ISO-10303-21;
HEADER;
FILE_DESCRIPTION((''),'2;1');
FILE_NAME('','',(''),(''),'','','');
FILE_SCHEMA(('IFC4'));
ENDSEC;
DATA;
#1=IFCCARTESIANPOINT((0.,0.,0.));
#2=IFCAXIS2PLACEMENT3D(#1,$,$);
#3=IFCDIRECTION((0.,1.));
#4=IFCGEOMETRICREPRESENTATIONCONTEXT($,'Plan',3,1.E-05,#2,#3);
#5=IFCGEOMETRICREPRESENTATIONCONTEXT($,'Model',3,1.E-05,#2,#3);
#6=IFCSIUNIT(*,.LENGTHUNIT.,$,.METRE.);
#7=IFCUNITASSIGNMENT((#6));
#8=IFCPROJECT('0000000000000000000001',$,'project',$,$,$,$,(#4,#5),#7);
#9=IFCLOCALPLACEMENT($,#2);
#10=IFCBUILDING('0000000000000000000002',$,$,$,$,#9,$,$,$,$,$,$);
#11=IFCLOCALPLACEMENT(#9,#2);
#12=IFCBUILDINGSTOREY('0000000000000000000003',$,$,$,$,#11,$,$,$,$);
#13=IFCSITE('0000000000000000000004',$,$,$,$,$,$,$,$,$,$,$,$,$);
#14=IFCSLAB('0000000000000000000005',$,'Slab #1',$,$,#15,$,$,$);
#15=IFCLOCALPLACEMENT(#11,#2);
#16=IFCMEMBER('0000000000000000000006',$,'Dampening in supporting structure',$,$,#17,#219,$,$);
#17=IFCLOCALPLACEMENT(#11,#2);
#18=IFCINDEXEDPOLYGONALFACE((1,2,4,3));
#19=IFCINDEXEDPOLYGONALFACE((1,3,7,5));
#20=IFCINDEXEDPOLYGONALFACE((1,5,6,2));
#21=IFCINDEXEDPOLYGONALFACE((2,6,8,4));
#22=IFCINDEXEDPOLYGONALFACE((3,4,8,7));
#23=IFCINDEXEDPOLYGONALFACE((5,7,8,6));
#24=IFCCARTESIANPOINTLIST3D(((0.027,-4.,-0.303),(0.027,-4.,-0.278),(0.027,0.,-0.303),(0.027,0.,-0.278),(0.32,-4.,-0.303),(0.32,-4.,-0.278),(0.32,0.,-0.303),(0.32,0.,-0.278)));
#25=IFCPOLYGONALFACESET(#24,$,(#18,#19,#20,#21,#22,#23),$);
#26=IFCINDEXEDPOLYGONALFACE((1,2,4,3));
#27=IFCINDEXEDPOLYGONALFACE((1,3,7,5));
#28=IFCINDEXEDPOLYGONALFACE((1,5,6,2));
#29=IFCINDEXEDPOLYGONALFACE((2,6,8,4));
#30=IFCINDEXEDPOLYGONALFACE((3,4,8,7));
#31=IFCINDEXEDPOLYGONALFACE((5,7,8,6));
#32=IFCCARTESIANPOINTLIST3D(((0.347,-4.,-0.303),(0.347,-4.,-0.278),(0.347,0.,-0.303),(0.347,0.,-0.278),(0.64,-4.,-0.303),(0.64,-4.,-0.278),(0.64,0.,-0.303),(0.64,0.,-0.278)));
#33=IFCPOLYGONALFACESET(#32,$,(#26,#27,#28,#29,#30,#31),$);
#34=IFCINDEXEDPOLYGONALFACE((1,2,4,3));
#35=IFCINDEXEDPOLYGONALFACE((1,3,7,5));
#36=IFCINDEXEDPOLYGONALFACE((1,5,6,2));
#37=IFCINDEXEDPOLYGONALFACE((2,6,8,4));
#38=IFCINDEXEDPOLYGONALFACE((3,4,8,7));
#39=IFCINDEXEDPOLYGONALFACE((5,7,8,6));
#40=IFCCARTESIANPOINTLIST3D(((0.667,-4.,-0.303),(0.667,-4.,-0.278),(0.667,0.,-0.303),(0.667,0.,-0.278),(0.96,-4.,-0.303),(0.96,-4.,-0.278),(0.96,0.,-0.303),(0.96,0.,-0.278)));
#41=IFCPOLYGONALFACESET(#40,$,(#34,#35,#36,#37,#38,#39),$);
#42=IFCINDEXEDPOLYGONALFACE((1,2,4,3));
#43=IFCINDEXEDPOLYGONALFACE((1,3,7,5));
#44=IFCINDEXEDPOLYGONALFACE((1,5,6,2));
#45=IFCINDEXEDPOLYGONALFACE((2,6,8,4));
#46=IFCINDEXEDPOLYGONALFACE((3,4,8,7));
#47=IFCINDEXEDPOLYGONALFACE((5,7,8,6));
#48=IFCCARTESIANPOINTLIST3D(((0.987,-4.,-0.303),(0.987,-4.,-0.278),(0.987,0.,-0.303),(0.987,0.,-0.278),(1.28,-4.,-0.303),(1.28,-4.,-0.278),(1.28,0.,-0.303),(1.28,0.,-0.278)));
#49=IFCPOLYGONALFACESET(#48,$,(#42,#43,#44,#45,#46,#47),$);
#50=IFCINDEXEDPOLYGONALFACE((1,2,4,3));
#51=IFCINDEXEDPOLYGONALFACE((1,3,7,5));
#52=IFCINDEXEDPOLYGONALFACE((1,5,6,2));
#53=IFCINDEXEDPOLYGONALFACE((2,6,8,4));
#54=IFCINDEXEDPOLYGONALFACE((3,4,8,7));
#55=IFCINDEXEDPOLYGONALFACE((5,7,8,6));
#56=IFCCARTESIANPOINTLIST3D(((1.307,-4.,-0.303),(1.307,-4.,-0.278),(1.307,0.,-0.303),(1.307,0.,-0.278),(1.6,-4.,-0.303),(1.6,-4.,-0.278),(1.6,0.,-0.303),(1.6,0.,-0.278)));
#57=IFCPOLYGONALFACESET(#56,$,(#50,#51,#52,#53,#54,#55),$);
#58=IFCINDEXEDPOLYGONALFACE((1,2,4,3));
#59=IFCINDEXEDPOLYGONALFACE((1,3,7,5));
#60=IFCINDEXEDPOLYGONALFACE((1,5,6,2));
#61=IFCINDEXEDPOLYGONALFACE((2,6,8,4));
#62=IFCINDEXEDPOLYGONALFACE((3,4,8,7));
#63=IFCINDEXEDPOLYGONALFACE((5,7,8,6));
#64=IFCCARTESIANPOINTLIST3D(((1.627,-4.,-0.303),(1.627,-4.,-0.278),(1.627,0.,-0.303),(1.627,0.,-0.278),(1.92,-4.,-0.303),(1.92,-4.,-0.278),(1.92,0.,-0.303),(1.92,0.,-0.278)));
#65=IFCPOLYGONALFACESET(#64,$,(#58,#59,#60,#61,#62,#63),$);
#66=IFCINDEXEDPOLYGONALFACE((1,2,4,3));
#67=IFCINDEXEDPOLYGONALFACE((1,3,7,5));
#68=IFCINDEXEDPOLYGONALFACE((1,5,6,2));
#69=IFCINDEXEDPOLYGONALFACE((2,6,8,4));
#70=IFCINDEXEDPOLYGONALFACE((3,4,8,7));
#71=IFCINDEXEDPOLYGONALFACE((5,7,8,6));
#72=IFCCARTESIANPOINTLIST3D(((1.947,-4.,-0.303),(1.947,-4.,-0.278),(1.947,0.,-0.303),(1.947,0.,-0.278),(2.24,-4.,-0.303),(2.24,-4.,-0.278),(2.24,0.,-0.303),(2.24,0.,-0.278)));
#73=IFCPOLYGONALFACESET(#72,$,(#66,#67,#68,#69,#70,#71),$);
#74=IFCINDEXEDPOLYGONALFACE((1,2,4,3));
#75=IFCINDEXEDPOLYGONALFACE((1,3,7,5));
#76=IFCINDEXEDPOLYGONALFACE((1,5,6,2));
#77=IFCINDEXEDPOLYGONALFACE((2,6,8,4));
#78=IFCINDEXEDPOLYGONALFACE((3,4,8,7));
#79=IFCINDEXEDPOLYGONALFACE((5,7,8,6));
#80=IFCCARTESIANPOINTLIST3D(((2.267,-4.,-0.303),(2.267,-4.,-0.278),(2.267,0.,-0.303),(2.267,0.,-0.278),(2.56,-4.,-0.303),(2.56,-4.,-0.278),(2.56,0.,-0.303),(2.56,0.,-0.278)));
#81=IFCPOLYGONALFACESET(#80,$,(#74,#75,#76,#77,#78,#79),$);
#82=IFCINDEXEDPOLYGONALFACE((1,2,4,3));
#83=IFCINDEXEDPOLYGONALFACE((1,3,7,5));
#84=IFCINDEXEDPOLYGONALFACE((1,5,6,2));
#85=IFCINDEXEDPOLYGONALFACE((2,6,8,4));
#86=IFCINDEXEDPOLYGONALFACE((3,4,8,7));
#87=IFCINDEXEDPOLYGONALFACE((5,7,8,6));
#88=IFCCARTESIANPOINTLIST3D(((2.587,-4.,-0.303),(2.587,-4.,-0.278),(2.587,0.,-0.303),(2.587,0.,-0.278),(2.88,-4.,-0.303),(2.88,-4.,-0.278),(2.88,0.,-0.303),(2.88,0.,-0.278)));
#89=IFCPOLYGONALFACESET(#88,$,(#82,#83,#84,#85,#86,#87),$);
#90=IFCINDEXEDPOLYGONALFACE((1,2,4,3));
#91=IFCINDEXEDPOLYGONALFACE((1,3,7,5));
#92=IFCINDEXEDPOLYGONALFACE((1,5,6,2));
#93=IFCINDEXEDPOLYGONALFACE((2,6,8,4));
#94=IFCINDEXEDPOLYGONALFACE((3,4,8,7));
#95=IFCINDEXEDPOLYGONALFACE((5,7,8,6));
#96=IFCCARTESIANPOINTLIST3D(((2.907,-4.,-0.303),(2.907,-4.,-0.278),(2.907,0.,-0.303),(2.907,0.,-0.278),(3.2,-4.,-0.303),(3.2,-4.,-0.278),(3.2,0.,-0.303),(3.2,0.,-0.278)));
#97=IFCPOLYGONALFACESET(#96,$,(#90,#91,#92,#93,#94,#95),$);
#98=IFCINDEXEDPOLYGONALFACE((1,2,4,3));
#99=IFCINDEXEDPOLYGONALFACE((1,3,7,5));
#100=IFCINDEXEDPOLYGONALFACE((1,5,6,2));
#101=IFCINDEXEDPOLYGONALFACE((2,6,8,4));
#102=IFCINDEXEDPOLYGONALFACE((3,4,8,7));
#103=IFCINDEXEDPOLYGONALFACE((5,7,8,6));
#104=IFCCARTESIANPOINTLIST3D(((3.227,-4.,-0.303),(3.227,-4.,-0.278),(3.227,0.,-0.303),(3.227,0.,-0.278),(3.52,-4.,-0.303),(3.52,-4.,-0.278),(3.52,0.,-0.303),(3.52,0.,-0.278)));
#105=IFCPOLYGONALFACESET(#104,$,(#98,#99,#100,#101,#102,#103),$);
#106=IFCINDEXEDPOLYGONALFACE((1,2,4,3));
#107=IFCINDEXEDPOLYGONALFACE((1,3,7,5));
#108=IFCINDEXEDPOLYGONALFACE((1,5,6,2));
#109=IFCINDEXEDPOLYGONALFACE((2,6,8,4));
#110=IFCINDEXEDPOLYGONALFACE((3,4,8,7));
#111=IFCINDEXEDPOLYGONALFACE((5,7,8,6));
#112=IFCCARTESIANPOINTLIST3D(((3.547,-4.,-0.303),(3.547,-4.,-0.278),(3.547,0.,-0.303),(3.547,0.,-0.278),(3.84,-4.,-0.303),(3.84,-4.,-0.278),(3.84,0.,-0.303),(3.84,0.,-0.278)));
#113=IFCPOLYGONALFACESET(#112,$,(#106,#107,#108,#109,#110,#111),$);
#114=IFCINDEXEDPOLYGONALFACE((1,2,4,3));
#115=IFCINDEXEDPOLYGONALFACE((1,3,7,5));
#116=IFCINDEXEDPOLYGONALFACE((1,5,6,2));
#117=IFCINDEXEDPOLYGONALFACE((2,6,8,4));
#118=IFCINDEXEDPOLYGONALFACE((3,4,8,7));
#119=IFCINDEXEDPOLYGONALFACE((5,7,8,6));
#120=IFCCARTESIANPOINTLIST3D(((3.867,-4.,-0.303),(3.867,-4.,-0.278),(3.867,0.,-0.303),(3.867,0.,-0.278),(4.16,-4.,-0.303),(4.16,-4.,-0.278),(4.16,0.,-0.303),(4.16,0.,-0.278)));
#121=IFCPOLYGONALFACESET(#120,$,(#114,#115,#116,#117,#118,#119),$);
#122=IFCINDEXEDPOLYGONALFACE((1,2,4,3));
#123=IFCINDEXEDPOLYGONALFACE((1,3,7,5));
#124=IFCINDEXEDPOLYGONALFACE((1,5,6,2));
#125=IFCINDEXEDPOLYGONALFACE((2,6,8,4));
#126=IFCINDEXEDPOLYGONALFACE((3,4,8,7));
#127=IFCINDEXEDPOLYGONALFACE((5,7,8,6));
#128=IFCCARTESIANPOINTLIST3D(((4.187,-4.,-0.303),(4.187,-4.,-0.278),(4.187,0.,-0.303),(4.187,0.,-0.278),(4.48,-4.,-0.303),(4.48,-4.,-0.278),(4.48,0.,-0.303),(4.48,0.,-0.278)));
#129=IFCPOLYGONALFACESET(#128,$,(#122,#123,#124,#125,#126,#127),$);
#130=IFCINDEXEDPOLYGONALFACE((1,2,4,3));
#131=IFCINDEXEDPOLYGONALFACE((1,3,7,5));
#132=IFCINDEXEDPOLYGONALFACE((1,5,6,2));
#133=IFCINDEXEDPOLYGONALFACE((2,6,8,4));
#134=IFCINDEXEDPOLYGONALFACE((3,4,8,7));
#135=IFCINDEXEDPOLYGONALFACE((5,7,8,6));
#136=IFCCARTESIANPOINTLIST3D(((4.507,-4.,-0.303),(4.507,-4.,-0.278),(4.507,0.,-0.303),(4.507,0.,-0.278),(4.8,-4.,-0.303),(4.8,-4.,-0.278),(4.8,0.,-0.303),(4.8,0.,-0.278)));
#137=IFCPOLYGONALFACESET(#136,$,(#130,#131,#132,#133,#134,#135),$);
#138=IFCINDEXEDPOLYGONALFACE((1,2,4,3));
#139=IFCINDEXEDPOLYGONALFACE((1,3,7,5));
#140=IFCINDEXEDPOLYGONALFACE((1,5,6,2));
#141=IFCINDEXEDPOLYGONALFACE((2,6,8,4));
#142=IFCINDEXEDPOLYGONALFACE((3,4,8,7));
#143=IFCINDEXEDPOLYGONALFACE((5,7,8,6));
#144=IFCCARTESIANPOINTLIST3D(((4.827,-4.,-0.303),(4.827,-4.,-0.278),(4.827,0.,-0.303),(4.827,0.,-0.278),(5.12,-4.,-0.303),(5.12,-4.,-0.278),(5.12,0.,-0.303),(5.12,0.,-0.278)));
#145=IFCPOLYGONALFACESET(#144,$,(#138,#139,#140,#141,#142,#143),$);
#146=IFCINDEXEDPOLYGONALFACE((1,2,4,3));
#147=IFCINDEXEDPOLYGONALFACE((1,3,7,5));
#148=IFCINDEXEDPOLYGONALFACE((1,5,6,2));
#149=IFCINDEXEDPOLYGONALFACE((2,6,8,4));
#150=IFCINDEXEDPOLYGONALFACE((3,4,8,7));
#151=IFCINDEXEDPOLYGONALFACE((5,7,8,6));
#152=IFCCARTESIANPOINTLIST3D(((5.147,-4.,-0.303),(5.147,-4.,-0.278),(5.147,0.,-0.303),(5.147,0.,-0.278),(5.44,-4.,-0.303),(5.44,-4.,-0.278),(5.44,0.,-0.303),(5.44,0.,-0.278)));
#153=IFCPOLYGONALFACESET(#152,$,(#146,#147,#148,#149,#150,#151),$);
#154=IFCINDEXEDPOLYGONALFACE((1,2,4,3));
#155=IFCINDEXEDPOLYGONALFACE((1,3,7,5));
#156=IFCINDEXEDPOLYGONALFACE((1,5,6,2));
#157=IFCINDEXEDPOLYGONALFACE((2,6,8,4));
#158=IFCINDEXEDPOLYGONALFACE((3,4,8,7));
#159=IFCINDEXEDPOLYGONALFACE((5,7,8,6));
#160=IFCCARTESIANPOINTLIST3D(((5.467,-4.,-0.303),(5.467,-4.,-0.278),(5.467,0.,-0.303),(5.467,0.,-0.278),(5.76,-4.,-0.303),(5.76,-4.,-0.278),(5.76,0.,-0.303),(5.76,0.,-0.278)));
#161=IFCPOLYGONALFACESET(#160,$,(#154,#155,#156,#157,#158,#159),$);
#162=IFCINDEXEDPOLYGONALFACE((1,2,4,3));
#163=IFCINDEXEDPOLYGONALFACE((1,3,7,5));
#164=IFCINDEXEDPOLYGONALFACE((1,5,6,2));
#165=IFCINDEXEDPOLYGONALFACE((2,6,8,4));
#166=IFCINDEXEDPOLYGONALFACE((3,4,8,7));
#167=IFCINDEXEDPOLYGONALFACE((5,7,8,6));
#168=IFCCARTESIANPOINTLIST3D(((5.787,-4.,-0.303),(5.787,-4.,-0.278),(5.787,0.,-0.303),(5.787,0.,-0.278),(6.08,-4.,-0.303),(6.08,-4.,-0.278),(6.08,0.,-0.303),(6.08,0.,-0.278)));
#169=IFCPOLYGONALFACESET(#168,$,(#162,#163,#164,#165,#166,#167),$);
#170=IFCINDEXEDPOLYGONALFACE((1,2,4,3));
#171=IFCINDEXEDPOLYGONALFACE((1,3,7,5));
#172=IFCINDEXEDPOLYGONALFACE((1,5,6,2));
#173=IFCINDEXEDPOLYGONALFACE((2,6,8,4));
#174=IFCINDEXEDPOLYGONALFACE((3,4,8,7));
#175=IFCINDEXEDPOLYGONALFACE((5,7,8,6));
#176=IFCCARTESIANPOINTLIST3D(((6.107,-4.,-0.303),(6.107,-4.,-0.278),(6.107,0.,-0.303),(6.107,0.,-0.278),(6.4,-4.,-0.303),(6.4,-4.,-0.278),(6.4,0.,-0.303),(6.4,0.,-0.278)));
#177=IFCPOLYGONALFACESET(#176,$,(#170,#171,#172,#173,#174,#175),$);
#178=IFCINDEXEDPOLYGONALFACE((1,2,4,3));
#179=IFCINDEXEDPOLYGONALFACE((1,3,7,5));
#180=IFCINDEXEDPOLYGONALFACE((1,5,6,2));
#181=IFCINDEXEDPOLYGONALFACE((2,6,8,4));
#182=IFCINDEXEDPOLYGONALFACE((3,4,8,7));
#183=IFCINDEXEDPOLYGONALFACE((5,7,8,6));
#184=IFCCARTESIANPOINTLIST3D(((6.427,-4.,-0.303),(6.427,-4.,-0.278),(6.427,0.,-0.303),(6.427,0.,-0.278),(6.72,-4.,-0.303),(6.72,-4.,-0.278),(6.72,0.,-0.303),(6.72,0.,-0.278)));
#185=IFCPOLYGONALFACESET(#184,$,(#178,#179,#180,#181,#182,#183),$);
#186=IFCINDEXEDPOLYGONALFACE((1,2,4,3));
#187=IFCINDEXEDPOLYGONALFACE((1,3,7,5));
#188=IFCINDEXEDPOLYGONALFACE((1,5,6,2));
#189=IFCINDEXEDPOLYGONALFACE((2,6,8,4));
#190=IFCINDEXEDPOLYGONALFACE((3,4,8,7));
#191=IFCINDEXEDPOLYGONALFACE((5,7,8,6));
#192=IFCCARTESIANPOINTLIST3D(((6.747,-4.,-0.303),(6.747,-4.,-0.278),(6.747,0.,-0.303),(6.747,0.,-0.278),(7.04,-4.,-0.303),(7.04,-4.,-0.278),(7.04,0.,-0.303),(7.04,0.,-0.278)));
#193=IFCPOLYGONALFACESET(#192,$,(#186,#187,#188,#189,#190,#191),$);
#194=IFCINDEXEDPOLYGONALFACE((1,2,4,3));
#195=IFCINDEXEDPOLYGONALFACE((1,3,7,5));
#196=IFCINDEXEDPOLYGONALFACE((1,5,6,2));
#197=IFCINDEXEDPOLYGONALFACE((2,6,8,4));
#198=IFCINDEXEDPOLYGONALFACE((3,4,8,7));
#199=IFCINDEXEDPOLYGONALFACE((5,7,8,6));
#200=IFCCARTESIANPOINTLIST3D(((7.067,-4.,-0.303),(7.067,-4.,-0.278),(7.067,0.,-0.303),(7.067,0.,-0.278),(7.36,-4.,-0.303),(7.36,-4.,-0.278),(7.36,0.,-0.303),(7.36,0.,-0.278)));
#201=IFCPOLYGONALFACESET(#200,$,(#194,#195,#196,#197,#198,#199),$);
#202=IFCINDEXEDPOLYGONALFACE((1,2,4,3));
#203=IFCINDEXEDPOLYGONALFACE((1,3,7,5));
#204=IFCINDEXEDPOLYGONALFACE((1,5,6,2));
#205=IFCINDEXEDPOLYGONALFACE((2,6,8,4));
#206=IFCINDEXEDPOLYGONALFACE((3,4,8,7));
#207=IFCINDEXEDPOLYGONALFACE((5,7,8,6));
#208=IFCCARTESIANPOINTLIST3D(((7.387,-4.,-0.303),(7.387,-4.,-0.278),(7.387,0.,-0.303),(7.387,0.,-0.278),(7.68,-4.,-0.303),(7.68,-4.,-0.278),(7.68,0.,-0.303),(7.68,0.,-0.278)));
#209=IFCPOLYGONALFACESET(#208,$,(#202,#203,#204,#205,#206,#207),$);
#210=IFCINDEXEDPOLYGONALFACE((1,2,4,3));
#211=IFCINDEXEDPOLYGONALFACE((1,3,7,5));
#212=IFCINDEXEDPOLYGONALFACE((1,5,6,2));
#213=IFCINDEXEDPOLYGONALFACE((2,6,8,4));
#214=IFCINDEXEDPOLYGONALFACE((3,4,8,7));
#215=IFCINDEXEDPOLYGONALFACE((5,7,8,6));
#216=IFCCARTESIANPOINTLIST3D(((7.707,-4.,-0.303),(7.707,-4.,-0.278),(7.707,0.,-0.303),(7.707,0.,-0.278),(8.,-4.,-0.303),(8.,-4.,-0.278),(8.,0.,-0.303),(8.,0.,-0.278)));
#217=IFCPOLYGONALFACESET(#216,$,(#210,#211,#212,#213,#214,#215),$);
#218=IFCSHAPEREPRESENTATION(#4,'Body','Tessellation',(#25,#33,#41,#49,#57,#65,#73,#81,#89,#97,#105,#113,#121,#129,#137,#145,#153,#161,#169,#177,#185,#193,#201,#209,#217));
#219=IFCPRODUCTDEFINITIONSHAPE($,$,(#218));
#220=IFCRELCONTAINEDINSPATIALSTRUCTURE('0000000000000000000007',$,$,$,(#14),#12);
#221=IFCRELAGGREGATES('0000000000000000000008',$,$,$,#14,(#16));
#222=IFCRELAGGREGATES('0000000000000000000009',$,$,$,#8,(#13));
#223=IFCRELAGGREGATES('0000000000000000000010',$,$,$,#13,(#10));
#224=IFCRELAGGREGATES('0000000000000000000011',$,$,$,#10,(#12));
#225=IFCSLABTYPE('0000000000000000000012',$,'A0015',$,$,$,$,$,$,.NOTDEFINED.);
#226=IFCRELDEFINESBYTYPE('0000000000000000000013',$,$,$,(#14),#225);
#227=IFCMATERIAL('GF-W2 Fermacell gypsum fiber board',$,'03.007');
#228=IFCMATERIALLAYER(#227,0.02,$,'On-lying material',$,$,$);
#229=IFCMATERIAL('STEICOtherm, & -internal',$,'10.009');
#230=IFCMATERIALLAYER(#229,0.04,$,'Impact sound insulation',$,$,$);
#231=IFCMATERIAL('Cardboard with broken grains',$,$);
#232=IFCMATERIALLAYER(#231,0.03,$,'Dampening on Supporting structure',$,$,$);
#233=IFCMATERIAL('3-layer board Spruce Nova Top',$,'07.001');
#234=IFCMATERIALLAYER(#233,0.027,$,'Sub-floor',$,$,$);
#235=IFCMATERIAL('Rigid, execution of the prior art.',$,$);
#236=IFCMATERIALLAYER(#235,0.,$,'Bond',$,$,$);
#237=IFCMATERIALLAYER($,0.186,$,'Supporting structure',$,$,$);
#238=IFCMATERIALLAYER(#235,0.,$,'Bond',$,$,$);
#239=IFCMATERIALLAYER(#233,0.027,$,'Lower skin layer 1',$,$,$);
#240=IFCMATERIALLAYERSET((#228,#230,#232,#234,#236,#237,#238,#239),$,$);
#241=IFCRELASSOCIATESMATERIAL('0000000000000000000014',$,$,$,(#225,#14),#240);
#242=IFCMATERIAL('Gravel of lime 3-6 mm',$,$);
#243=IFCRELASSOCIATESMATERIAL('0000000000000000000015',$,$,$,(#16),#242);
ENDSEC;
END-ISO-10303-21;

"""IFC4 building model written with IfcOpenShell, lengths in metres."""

from ifc_helpers import new_model, si_unit, direction, frame, frame_2d, origin, place, context, project, spatial, rectangle, extrude, material, layer, layer_set, type_object, element, aggregate, save


model = new_model("IFC4")

# Units and contexts
plan_context = context("Plan", 3, precision=1e-05, world=origin(), true_north=direction((0.0, 1.0)))
model_context = context("Model", 3, precision=1e-05, world=origin(), true_north=direction((0.0, 1.0)))
ifc_project = project(units=[si_unit("LENGTHUNIT", "METRE")], contexts=[plan_context, model_context])

# Site, building, storey
site = spatial("IfcSite", under=ifc_project)
building_placement = place(None, origin())
building = spatial("IfcBuilding", under=site, at=building_placement)
storey_placement = place(building_placement, origin())
storey = spatial("IfcBuildingStorey", under=building, at=storey_placement)

# Slab, member
ifc_material_1 = material(Name="GF-W2 Fermacell gypsum fiber board", Category="03.007")
ifc_layer_1 = layer(ifc_material_1, 0.02, Name="On-lying material")
ifc_material_2 = material(Name="STEICOtherm, & -internal", Category="10.009")
ifc_layer_2 = layer(ifc_material_2, 0.04, Name="Impact sound insulation")
ifc_material_3 = material(Name="Cardboard with broken grains")
ifc_layer_3 = layer(ifc_material_3, 0.03, Name="Dampening on Supporting structure")
ifc_material_4 = material(Name="3-layer board Spruce Nova Top", Category="07.001")
ifc_layer_4 = layer(ifc_material_4, 0.027, Name="Sub-floor")
ifc_material_5 = material(Name="Rigid, execution of the prior art.")
ifc_layer_5 = layer(ifc_material_5, 0.0, Name="Bond")
ifc_layer_6 = layer(None, 0.186, Name="Supporting structure")
ifc_layer_7 = layer(ifc_material_5, 0.0, Name="Bond")
ifc_layer_8 = layer(ifc_material_4, 0.027, Name="Lower skin layer 1")
ifc_layer_set = layer_set([ifc_layer_1, ifc_layer_2, ifc_layer_3, ifc_layer_4, ifc_layer_5, ifc_layer_6, ifc_layer_7, ifc_layer_8])
slab_type = type_object("IfcSlabType", Name="A0015", PredefinedType="NOTDEFINED", material=ifc_layer_set)
slab_placement = place(None, frame((0.0, 0.0, 0.0), z_axis=(0.0, 0.0, -1.0), x_axis=(1.0, 0.0, 0.0)))
slab = element("IfcSlab", 1, at=slab_placement, inside=storey, type_object=slab_type, material=ifc_layer_set, Name="Slab #1")
ifc_material_6 = material(Name="Gravel of lime 3-6 mm")
member_1_placement = place(slab_placement, origin())
member_1 = element("IfcMember", 2, at=member_1_placement, material=ifc_material_6, Name="Dampening in supporting structure", context=plan_context, shape_type="SweptSolid", body=[
    extrude(rectangle(XDim=0.293, YDim=0.025, at=frame_2d((0.1465, 0.0125), x_axis=(1.0, 0.0))), frame((0.027, 4.0, 0.278), z_axis=(0.0, -1.0, 0.0), x_axis=(1.0, 0.0, 0.0)), (0.0, 0.0, 1.0), 4.0),
    extrude(rectangle(XDim=0.293, YDim=0.025, at=frame_2d((0.1465, 0.0125), x_axis=(1.0, 0.0))), frame((0.347, 4.0, 0.278), z_axis=(0.0, -1.0, 0.0), x_axis=(1.0, 0.0, 0.0)), (0.0, 0.0, 1.0), 4.0),
    extrude(rectangle(XDim=0.293, YDim=0.025, at=frame_2d((0.1465, 0.0125), x_axis=(1.0, 0.0))), frame((0.667, 4.0, 0.278), z_axis=(0.0, -1.0, 0.0), x_axis=(1.0, 0.0, 0.0)), (0.0, 0.0, 1.0), 4.0),
    extrude(rectangle(XDim=0.293, YDim=0.025, at=frame_2d((0.1465, 0.0125), x_axis=(1.0, 0.0))), frame((0.987, 4.0, 0.278), z_axis=(0.0, -1.0, 0.0), x_axis=(1.0, 0.0, 0.0)), (0.0, 0.0, 1.0), 4.0),
    extrude(rectangle(XDim=0.293, YDim=0.025, at=frame_2d((0.1465, 0.0125), x_axis=(1.0, 0.0))), frame((1.307, 4.0, 0.278), z_axis=(0.0, -1.0, 0.0), x_axis=(1.0, 0.0, 0.0)), (0.0, 0.0, 1.0), 4.0),
    extrude(rectangle(XDim=0.293, YDim=0.025, at=frame_2d((0.1465, 0.0125), x_axis=(1.0, 0.0))), frame((1.627, 4.0, 0.278), z_axis=(0.0, -1.0, 0.0), x_axis=(1.0, 0.0, 0.0)), (0.0, 0.0, 1.0), 4.0),
    extrude(rectangle(XDim=0.293, YDim=0.025, at=frame_2d((0.1465, 0.0125), x_axis=(1.0, 0.0))), frame((1.947, 4.0, 0.278), z_axis=(0.0, -1.0, 0.0), x_axis=(1.0, 0.0, 0.0)), (0.0, 0.0, 1.0), 4.0),
    extrude(rectangle(XDim=0.293, YDim=0.025, at=frame_2d((0.1465, 0.0125), x_axis=(1.0, 0.0))), frame((2.267, 4.0, 0.278), z_axis=(0.0, -1.0, 0.0), x_axis=(1.0, 0.0, 0.0)), (0.0, 0.0, 1.0), 4.0),
    extrude(rectangle(XDim=0.293, YDim=0.025, at=frame_2d((0.1465, 0.0125), x_axis=(1.0, 0.0))), frame((2.587, 4.0, 0.278), z_axis=(0.0, -1.0, 0.0), x_axis=(1.0, 0.0, 0.0)), (0.0, 0.0, 1.0), 4.0),
    extrude(rectangle(XDim=0.293, YDim=0.025, at=frame_2d((0.1465, 0.0125), x_axis=(1.0, 0.0))), frame((2.907, 4.0, 0.278), z_axis=(0.0, -1.0, 0.0), x_axis=(1.0, 0.0, 0.0)), (0.0, 0.0, 1.0), 4.0),
    extrude(rectangle(XDim=0.293, YDim=0.025, at=frame_2d((0.1465, 0.0125), x_axis=(1.0, 0.0))), frame((3.227, 4.0, 0.278), z_axis=(0.0, -1.0, 0.0), x_axis=(1.0, 0.0, 0.0)), (0.0, 0.0, 1.0), 4.0),
    extrude(rectangle(XDim=0.293, YDim=0.025, at=frame_2d((0.1465, 0.0125), x_axis=(1.0, 0.0))), frame((3.547, 4.0, 0.278), z_axis=(0.0, -1.0, 0.0), x_axis=(1.0, 0.0, 0.0)), (0.0, 0.0, 1.0), 4.0),
    extrude(rectangle(XDim=0.293, YDim=0.025, at=frame_2d((0.1465, 0.0125), x_axis=(1.0, 0.0))), frame((3.867, 4.0, 0.278), z_axis=(0.0, -1.0, 0.0), x_axis=(1.0, 0.0, 0.0)), (0.0, 0.0, 1.0), 4.0),
    extrude(rectangle(XDim=0.293, YDim=0.025, at=frame_2d((0.1465, 0.0125), x_axis=(1.0, 0.0))), frame((4.187, 4.0, 0.278), z_axis=(0.0, -1.0, 0.0), x_axis=(1.0, 0.0, 0.0)), (0.0, 0.0, 1.0), 4.0),
    extrude(rectangle(XDim=0.293, YDim=0.025, at=frame_2d((0.1465, 0.0125), x_axis=(1.0, 0.0))), frame((4.507, 4.0, 0.278), z_axis=(0.0, -1.0, 0.0), x_axis=(1.0, 0.0, 0.0)), (0.0, 0.0, 1.0), 4.0),
    extrude(rectangle(XDim=0.293, YDim=0.025, at=frame_2d((0.1465, 0.0125), x_axis=(1.0, 0.0))), frame((4.827, 4.0, 0.278), z_axis=(0.0, -1.0, 0.0), x_axis=(1.0, 0.0, 0.0)), (0.0, 0.0, 1.0), 4.0),
    extrude(rectangle(XDim=0.293, YDim=0.025, at=frame_2d((0.1465, 0.0125), x_axis=(1.0, 0.0))), frame((5.147, 4.0, 0.278), z_axis=(0.0, -1.0, 0.0), x_axis=(1.0, 0.0, 0.0)), (0.0, 0.0, 1.0), 4.0),
    extrude(rectangle(XDim=0.293, YDim=0.025, at=frame_2d((0.1465, 0.0125), x_axis=(1.0, 0.0))), frame((5.467, 4.0, 0.278), z_axis=(0.0, -1.0, 0.0), x_axis=(1.0, 0.0, 0.0)), (0.0, 0.0, 1.0), 4.0),
    extrude(rectangle(XDim=0.293, YDim=0.025, at=frame_2d((0.1465, 0.0125), x_axis=(1.0, 0.0))), frame((5.787, 4.0, 0.278), z_axis=(0.0, -1.0, 0.0), x_axis=(1.0, 0.0, 0.0)), (0.0, 0.0, 1.0), 4.0),
    extrude(rectangle(XDim=0.293, YDim=0.025, at=frame_2d((0.1465, 0.0125), x_axis=(1.0, 0.0))), frame((6.107, 4.0, 0.278), z_axis=(0.0, -1.0, 0.0), x_axis=(1.0, 0.0, 0.0)), (0.0, 0.0, 1.0), 4.0),
    extrude(rectangle(XDim=0.293, YDim=0.025, at=frame_2d((0.1465, 0.0125), x_axis=(1.0, 0.0))), frame((6.427, 4.0, 0.278), z_axis=(0.0, -1.0, 0.0), x_axis=(1.0, 0.0, 0.0)), (0.0, 0.0, 1.0), 4.0),
    extrude(rectangle(XDim=0.293, YDim=0.025, at=frame_2d((0.1465, 0.0125), x_axis=(1.0, 0.0))), frame((6.747, 4.0, 0.278), z_axis=(0.0, -1.0, 0.0), x_axis=(1.0, 0.0, 0.0)), (0.0, 0.0, 1.0), 4.0),
    extrude(rectangle(XDim=0.293, YDim=0.025, at=frame_2d((0.1465, 0.0125), x_axis=(1.0, 0.0))), frame((7.067, 4.0, 0.278), z_axis=(0.0, -1.0, 0.0), x_axis=(1.0, 0.0, 0.0)), (0.0, 0.0, 1.0), 4.0),
    extrude(rectangle(XDim=0.293, YDim=0.025, at=frame_2d((0.1465, 0.0125), x_axis=(1.0, 0.0))), frame((7.387, 4.0, 0.278), z_axis=(0.0, -1.0, 0.0), x_axis=(1.0, 0.0, 0.0)), (0.0, 0.0, 1.0), 4.0),
    extrude(rectangle(XDim=0.293, YDim=0.025, at=frame_2d((0.1465, 0.0125), x_axis=(1.0, 0.0))), frame((7.707, 4.0, 0.278), z_axis=(0.0, -1.0, 0.0), x_axis=(1.0, 0.0, 0.0)), (0.0, 0.0, 1.0), 4.0),
])
aggregate(slab, [member_1])

save(model, "model.ifc")
